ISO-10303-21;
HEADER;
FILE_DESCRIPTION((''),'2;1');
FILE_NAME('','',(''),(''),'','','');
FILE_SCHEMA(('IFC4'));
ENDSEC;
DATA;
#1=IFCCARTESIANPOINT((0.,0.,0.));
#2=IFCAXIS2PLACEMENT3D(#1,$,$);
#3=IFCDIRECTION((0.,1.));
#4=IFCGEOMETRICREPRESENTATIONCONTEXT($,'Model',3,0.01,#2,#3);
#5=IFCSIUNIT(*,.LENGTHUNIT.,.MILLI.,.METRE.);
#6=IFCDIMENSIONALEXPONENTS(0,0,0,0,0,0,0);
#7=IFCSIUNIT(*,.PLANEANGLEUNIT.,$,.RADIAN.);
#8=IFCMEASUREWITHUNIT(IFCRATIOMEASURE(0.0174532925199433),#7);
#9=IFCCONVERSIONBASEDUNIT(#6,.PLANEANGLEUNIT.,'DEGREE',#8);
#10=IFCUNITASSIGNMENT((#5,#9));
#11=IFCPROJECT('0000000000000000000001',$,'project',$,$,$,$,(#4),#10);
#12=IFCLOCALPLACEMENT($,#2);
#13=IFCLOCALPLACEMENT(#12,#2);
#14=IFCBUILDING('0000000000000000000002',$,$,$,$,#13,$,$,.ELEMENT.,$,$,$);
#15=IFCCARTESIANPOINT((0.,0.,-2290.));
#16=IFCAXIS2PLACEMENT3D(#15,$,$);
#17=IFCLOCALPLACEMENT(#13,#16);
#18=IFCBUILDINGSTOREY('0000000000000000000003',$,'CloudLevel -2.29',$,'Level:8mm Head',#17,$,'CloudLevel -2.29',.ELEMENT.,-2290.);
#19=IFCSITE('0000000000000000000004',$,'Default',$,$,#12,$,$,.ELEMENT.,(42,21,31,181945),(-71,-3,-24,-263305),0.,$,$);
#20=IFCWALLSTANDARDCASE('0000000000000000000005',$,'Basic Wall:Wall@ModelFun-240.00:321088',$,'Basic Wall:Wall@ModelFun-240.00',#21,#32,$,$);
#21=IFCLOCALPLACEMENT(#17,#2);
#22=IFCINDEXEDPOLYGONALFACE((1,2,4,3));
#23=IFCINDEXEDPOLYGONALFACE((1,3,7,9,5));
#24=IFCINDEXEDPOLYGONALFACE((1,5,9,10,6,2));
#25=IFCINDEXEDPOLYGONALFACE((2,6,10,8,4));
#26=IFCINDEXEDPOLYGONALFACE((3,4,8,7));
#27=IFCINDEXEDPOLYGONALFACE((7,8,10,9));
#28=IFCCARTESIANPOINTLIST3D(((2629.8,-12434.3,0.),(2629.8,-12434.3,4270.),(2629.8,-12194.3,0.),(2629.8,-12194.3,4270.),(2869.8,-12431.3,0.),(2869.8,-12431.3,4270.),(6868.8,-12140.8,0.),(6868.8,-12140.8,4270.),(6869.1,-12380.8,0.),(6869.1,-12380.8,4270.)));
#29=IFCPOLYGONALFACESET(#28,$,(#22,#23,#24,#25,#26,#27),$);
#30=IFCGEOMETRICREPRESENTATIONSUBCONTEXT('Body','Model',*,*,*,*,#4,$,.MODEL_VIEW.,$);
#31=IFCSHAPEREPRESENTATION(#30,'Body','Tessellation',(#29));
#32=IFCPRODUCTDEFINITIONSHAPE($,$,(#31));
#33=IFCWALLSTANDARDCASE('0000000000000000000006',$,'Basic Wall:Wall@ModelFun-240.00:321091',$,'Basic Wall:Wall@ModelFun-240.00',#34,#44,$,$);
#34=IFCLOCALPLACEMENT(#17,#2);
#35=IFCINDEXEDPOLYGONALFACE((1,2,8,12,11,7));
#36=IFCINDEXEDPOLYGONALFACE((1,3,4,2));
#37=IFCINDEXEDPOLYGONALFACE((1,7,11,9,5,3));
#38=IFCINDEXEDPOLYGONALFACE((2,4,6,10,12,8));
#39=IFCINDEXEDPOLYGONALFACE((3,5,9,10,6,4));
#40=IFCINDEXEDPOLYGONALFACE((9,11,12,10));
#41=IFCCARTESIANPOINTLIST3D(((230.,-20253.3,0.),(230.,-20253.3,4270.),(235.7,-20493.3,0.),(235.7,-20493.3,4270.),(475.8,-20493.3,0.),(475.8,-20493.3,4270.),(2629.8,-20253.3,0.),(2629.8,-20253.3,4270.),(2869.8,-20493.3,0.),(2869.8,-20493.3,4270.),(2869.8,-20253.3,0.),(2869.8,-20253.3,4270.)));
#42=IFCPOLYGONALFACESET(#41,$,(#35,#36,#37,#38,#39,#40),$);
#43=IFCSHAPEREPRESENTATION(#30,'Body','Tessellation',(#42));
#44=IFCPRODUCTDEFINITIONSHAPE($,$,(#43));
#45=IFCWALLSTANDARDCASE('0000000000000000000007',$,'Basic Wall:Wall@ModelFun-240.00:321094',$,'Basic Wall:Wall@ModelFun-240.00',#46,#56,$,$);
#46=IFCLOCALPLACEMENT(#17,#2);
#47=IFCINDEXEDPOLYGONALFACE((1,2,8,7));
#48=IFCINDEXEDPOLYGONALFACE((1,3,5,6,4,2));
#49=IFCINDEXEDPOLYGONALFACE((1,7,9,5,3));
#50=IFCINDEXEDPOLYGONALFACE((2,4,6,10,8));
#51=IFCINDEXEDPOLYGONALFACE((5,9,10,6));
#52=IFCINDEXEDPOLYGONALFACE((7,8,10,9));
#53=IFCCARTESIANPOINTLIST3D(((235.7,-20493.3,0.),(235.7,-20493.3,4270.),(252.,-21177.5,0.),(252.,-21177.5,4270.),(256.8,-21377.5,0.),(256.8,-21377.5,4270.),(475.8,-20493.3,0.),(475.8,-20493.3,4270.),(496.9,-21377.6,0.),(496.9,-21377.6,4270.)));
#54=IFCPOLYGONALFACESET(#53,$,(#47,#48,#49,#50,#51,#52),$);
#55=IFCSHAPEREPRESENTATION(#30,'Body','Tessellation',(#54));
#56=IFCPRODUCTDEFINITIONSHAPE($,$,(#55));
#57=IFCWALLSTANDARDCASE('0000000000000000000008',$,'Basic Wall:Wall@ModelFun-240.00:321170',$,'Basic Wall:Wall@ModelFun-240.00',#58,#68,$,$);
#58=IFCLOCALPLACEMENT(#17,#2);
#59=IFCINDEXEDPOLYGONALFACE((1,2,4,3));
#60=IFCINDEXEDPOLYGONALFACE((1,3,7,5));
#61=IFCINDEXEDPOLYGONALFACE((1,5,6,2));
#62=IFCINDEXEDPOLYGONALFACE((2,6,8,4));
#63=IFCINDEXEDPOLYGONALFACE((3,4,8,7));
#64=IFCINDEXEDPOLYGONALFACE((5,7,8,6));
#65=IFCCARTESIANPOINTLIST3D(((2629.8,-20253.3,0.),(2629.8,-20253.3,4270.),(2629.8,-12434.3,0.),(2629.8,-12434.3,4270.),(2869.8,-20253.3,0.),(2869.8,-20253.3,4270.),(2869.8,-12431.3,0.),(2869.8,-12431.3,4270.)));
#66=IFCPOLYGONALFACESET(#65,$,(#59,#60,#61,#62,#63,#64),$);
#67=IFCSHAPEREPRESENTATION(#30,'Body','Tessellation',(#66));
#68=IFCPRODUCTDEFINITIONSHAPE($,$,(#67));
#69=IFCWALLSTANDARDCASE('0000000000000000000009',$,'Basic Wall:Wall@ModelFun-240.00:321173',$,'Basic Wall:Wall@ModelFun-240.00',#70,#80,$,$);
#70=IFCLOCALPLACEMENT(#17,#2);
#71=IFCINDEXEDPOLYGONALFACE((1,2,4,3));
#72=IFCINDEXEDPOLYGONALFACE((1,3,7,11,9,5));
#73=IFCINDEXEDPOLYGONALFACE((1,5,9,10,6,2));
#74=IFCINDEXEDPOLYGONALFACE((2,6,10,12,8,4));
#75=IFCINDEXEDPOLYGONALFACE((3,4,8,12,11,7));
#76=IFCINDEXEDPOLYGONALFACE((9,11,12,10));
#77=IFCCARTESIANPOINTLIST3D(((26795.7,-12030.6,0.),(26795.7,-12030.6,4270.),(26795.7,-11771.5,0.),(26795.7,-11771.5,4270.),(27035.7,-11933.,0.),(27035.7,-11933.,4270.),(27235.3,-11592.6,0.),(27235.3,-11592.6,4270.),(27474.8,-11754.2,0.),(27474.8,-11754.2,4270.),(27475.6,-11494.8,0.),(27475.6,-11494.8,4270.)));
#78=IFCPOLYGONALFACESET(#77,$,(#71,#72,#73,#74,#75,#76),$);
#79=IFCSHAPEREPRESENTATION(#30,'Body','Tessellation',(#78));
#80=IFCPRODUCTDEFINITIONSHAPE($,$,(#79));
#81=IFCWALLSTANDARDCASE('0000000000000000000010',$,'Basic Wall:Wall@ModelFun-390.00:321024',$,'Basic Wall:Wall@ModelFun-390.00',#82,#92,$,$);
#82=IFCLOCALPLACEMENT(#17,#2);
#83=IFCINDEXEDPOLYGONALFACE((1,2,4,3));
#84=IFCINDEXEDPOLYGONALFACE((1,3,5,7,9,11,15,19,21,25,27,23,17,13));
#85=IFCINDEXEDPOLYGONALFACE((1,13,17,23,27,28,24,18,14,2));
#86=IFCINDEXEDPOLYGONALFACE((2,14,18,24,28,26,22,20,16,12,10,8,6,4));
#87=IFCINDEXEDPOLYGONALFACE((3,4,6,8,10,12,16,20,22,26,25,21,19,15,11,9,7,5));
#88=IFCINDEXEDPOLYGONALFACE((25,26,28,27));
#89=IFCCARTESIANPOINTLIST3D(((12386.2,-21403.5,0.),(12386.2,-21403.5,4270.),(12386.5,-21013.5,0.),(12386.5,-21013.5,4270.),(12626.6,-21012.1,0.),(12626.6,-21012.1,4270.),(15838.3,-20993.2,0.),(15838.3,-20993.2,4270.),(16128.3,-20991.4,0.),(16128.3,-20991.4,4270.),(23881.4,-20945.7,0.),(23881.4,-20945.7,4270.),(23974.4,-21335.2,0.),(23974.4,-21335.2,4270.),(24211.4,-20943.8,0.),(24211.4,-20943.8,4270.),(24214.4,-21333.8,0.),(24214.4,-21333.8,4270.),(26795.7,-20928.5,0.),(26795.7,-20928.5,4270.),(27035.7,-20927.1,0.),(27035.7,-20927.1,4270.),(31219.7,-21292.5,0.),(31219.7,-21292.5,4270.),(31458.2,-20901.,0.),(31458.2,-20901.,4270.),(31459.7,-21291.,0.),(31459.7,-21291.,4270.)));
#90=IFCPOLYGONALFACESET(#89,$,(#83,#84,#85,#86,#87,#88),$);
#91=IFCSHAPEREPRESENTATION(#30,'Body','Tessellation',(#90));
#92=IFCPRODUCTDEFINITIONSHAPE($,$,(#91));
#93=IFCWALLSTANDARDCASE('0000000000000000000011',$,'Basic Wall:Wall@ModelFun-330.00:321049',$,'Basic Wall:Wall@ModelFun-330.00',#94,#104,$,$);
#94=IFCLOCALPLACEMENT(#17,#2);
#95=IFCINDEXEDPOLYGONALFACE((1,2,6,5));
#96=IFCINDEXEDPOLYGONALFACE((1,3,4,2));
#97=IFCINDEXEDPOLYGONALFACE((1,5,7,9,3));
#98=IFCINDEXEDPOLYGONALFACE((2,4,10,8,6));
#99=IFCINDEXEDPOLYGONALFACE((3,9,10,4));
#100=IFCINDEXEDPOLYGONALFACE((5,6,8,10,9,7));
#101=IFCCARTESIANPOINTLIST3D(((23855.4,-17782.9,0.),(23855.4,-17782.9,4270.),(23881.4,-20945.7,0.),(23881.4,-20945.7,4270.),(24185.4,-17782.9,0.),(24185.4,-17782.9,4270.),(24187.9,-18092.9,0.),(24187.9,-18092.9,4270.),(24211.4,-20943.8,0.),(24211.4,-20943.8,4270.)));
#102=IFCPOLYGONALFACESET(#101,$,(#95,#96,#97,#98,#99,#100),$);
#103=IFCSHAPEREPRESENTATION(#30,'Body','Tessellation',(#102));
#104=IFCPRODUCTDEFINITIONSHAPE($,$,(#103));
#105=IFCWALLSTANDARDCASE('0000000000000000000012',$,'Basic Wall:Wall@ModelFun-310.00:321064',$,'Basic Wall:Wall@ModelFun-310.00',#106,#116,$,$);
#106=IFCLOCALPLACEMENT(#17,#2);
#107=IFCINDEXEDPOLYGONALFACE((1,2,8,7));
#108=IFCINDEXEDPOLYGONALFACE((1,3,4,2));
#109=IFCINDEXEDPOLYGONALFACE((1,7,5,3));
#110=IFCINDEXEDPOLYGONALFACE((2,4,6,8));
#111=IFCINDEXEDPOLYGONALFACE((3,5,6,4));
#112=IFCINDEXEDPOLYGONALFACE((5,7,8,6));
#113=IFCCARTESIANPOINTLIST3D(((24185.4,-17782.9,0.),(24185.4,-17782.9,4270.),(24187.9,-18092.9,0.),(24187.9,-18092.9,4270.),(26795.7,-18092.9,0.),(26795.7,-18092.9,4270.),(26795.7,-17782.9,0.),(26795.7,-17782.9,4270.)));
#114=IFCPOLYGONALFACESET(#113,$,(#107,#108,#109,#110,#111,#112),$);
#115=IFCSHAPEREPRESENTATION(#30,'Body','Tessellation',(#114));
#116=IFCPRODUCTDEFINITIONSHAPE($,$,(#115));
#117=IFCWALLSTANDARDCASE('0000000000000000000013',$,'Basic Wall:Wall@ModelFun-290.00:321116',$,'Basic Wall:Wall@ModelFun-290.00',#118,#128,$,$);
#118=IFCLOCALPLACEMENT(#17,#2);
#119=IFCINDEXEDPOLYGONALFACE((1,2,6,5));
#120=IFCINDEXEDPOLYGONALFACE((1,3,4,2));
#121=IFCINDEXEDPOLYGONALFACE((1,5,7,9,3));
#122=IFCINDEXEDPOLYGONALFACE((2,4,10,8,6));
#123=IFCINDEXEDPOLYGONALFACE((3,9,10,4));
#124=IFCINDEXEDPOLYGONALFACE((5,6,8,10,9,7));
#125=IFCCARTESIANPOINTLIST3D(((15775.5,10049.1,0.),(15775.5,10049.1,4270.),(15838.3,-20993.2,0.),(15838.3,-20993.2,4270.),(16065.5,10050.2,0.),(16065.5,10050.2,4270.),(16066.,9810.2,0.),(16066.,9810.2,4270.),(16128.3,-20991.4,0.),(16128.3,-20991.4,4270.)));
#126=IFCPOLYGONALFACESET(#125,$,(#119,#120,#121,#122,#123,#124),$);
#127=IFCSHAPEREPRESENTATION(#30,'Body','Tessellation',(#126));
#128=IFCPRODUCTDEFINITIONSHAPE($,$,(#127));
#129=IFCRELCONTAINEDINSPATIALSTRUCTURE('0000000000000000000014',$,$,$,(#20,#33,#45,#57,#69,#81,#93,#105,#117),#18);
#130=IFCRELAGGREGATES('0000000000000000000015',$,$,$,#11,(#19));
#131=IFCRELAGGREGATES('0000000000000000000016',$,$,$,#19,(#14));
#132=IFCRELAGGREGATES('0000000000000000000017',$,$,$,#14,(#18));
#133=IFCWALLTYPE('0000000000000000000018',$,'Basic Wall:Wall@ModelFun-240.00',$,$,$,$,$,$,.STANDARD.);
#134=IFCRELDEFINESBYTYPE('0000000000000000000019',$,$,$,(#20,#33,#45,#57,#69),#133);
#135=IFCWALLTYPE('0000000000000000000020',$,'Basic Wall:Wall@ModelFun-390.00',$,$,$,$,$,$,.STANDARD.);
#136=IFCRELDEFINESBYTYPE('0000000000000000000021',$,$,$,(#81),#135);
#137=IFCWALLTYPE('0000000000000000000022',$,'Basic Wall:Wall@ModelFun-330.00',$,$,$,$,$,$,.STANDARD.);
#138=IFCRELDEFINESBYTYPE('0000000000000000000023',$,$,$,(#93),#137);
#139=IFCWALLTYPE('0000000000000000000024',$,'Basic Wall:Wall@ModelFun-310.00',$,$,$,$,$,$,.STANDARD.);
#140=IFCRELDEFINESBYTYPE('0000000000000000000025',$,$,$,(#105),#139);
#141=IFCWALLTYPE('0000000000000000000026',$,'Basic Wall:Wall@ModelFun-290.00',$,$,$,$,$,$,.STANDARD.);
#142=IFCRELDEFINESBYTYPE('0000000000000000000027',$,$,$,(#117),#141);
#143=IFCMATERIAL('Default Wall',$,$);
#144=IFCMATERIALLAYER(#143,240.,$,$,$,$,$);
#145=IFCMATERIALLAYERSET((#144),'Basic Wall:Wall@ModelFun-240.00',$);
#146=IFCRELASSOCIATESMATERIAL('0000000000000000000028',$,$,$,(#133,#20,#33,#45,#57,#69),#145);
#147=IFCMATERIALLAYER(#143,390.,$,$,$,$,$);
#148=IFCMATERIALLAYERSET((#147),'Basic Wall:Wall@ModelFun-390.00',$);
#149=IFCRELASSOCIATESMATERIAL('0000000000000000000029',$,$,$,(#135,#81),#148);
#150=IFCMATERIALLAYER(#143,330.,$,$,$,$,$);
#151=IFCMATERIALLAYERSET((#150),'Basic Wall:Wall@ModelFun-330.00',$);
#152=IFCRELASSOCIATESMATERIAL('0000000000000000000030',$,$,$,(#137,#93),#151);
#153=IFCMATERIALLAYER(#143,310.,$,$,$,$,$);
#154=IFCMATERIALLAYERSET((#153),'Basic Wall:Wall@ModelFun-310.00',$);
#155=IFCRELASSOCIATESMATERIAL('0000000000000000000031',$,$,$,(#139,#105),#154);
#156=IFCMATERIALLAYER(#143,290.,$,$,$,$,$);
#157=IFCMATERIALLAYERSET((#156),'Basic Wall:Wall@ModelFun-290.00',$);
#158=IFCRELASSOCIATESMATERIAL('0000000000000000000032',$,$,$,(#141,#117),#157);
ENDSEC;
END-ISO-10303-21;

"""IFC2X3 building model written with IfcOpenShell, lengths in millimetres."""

from ifc_helpers import new_model, entity, si_unit, converted_unit, direction, frame, origin, place, context, subcontext, project, spatial, polyline, outline, extrude, material, layer, layer_set, layer_usage, type_object, element, save


model = new_model("IFC2X3")

# Units and contexts
model_context = context("Model", 3, precision=0.01, world=origin(), true_north=direction((0.0, 1.0)))
body_context = subcontext(model_context, "Body", "Model", "MODEL_VIEW")
ifc_project = project(units=[si_unit("LENGTHUNIT", "METRE", prefix="MILLI"), converted_unit("PLANEANGLEUNIT", "DEGREE", entity("IfcRatioMeasure", 0.0174532925199433), si_unit("PLANEANGLEUNIT", "RADIAN"), dimensions=[0, 0, 0, 0, 0, 0, 0])], contexts=[model_context])

# Site, building, storey
site_placement = place(None, origin())
site = spatial("IfcSite", under=ifc_project, at=site_placement, Name="Default", CompositionType="ELEMENT", RefLatitude=(42, 21, 31, 181945), RefLongitude=(-71, -3, -24, -263305), RefElevation=0.0)
building_placement = place(site_placement, origin())
building = spatial("IfcBuilding", under=site, at=building_placement, CompositionType="ELEMENT")
storey_placement = place(building_placement, frame((0.0, 0.0, -2290.0)))
storey = spatial("IfcBuildingStorey", under=building, at=storey_placement, Name="CloudLevel -2.29", ObjectType="Level:8mm Head", LongName="CloudLevel -2.29", CompositionType="ELEMENT", Elevation=-2290.0)

# Walls
ifc_material_1 = material(Name="Default Wall")
ifc_layer_1 = layer(ifc_material_1, 240.0)
ifc_layer_set_1 = layer_set([ifc_layer_1], Name="Basic Wall:Wall@ModelFun-240.00")
wall_type_1 = type_object("IfcWallType", Name="Basic Wall:Wall@ModelFun-240.00", PredefinedType="STANDARD", material=ifc_layer_set_1)
ifc_layer_usage_1 = layer_usage(ifc_layer_set_1, "AXIS2", "NEGATIVE", 120.0)
wall_1_placement = place(storey_placement, frame((2628.3, -12314.3, 0.0), z_axis=(0.0, 0.0, 1.0), x_axis=(0.99992, 0.012621, 0.0)))
element("IfcWallStandardCase", 1, at=wall_1_placement, inside=storey, type_object=wall_type_1, material=ifc_layer_usage_1, Name="Basic Wall:Wall@ModelFun-240.00:321088", ObjectType="Basic Wall:Wall@ModelFun-240.00", context=body_context, shape_type="SweptSolid", body=[
    extrude(outline(polyline([(4239.6, -120.0), (4242.3, 120.0), (3.0, 120.0), (0.0, -120.0), (240.0, -120.0), (4239.6, -120.0)])), origin(), (0.0, 0.0, 1.0), 4270.0),
])
ifc_layer_usage_2 = layer_usage(ifc_layer_set_1, "AXIS2", "NEGATIVE", 120.0)
wall_2_placement = place(storey_placement, frame((2869.8, -20373.3, 0.0), z_axis=(0.0, 0.0, 1.0), x_axis=(-1.0, 0.0, 0.0)))
element("IfcWallStandardCase", 2, at=wall_2_placement, inside=storey, type_object=wall_type_1, material=ifc_layer_usage_2, Name="Basic Wall:Wall@ModelFun-240.00:321091", ObjectType="Basic Wall:Wall@ModelFun-240.00", context=body_context, shape_type="SweptSolid", body=[
    extrude(outline(polyline([(2639.8, -120.0), (2634.1, 120.0), (2394.0, 120.0), (0.0, 120.0), (0.0, -120.0), (240.0, -120.0), (2639.8, -120.0)])), origin(), (0.0, 0.0, 1.0), 4270.0),
])
ifc_layer_usage_3 = layer_usage(ifc_layer_set_1, "AXIS2", "NEGATIVE", 120.0)
wall_3_placement = place(storey_placement, frame((376.9, -21380.4, 0.0), z_axis=(0.0, 0.0, 1.0), x_axis=(-0.023839, 0.999716, 0.0)))
element("IfcWallStandardCase", 3, at=wall_3_placement, inside=storey, type_object=wall_type_1, material=ifc_layer_usage_3, Name="Basic Wall:Wall@ModelFun-240.00:321094", ObjectType="Basic Wall:Wall@ModelFun-240.00", context=body_context, shape_type="SweptSolid", body=[
    extrude(outline(polyline([(884.5, -120.0), (890.2, 120.0), (205.9, 120.0), (5.8, 120.0), (0.0, -120.0), (884.5, -120.0)])), origin(), (0.0, 0.0, 1.0), 4270.0),
])
ifc_layer_usage_4 = layer_usage(ifc_layer_set_1, "AXIS2", "NEGATIVE", 120.0)
wall_4_placement = place(storey_placement, frame((2749.8, -20253.3, 0.0), z_axis=(0.0, 0.0, 1.0), x_axis=(0.0, 1.0, 0.0)))
element("IfcWallStandardCase", 4, at=wall_4_placement, inside=storey, type_object=wall_type_1, material=ifc_layer_usage_4, Name="Basic Wall:Wall@ModelFun-240.00:321170", ObjectType="Basic Wall:Wall@ModelFun-240.00", context=body_context, shape_type="SweptSolid", body=[
    extrude(outline(polyline([(7822.0, -120.0), (7819.0, 120.0), (0.0, 120.0), (0.0, -120.0), (7822.0, -120.0)])), origin(), (0.0, 0.0, 1.0), 4270.0),
])
ifc_layer_usage_5 = layer_usage(ifc_layer_set_1, "AXIS2", "NEGATIVE", 120.0)
wall_5_placement = place(storey_placement, frame((27520.8, -11606.0, 0.0), z_axis=(0.0, 0.0, 1.0), x_axis=(-0.926248, -0.376915, 0.0)))
element("IfcWallStandardCase", 5, at=wall_5_placement, inside=storey, type_object=wall_type_1, material=ifc_layer_usage_5, Name="Basic Wall:Wall@ModelFun-240.00:321173", ObjectType="Basic Wall:Wall@ModelFun-240.00", context=body_context, shape_type="SweptSolid", body=[
    extrude(outline(polyline([(734.1, -120.0), (831.7, 120.0), (572.6, 120.0), (98.5, 120.0), (0.0, -120.0), (259.4, -120.0), (734.1, -120.0)])), origin(), (0.0, 0.0, 1.0), 4270.0),
])
ifc_layer_2 = layer(ifc_material_1, 390.0)
ifc_layer_set_2 = layer_set([ifc_layer_2], Name="Basic Wall:Wall@ModelFun-390.00")
ifc_layer_usage_6 = layer_usage(ifc_layer_set_2, "AXIS2", "NEGATIVE", 195.0)
wall_type_2 = type_object("IfcWallType", Name="Basic Wall:Wall@ModelFun-390.00", PredefinedType="STANDARD", material=ifc_layer_set_2)
wall_6_placement = place(storey_placement, frame((31459.3, -21096.0, 0.0), z_axis=(0.0, 0.0, 1.0), x_axis=(-0.999983, -0.005897, 0.0)))
element("IfcWallStandardCase", 6, at=wall_6_placement, inside=storey, type_object=wall_type_2, material=ifc_layer_usage_6, Name="Basic Wall:Wall@ModelFun-390.00:321024", ObjectType="Basic Wall:Wall@ModelFun-390.00", context=body_context, shape_type="SweptSolid", body=[
    extrude(outline(polyline([(19072.0, -195.0), (19074.6, 195.0), (7486.2, 195.0), (7246.2, 195.0), (240.8, 195.0), (0.8, 195.0), (0.0, -195.0), (4422.6, -195.0), (4662.6, -195.0), (7246.9, -195.0), (7576.9, -195.0), (15330.1, -195.0), (15620.1, -195.0), (18832.0, -195.0), (19072.0, -195.0)])), origin(), (0.0, 0.0, 1.0), 4270.0),
])
ifc_layer_3 = layer(ifc_material_1, 330.0)
ifc_layer_set_3 = layer_set([ifc_layer_3], Name="Basic Wall:Wall@ModelFun-330.00")
ifc_layer_usage_7 = layer_usage(ifc_layer_set_3, "AXIS2", "NEGATIVE", 165.0)
wall_type_3 = type_object("IfcWallType", Name="Basic Wall:Wall@ModelFun-330.00", PredefinedType="STANDARD", material=ifc_layer_set_3)
wall_7_placement = place(storey_placement, frame((24046.4, -20945.1, 0.0), z_axis=(0.0, 0.0, 1.0), x_axis=(-0.008236, 0.999966, 0.0)))
element("IfcWallStandardCase", 7, at=wall_7_placement, inside=storey, type_object=wall_type_3, material=ifc_layer_usage_7, Name="Basic Wall:Wall@ModelFun-330.00:321049", ObjectType="Basic Wall:Wall@ModelFun-330.00", context=body_context, shape_type="SweptSolid", body=[
    extrude(outline(polyline([(3161.0, -165.0), (3163.7, 165.0), (0.8, 165.0), (0.0, -165.0), (2851.0, -165.0), (3161.0, -165.0)])), origin(), (0.0, 0.0, 1.0), 4270.0),
])
ifc_layer_4 = layer(ifc_material_1, 310.0)
ifc_layer_set_4 = layer_set([ifc_layer_4], Name="Basic Wall:Wall@ModelFun-310.00")
ifc_layer_usage_8 = layer_usage(ifc_layer_set_4, "AXIS2", "NEGATIVE", 155.0)
wall_type_4 = type_object("IfcWallType", Name="Basic Wall:Wall@ModelFun-310.00", PredefinedType="STANDARD", material=ifc_layer_set_4)
wall_8_placement = place(storey_placement, frame((24185.4, -17937.9, 0.0)))
element("IfcWallStandardCase", 8, at=wall_8_placement, inside=storey, type_object=wall_type_4, material=ifc_layer_usage_8, Name="Basic Wall:Wall@ModelFun-310.00:321064", ObjectType="Basic Wall:Wall@ModelFun-310.00", context=body_context, shape_type="SweptSolid", body=[
    extrude(outline(polyline([(2610.3, -155.0), (2610.3, 155.0), (0.0, 155.0), (2.6, -155.0), (2610.3, -155.0)])), origin(), (0.0, 0.0, 1.0), 4270.0),
])
ifc_layer_5 = layer(ifc_material_1, 290.0)
ifc_layer_set_5 = layer_set([ifc_layer_5], Name="Basic Wall:Wall@ModelFun-290.00")
ifc_layer_usage_9 = layer_usage(ifc_layer_set_5, "AXIS2", "NEGATIVE", 145.0)
wall_type_5 = type_object("IfcWallType", Name="Basic Wall:Wall@ModelFun-290.00", PredefinedType="STANDARD", material=ifc_layer_set_5)
wall_9_placement = place(storey_placement, frame((15983.3, -20992.9, 0.0), z_axis=(0.0, 0.0, 1.0), x_axis=(-0.002024, 0.999998, 0.0)))
element("IfcWallStandardCase", 9, at=wall_9_placement, inside=storey, type_object=wall_type_5, material=ifc_layer_usage_9, Name="Basic Wall:Wall@ModelFun-290.00:321116", ObjectType="Basic Wall:Wall@ModelFun-290.00", context=body_context, shape_type="SweptSolid", body=[
    extrude(outline(polyline([(31042.8, -145.0), (31042.3, 145.0), (0.0, 145.0), (1.1, -145.0), (30802.8, -145.0), (31042.8, -145.0)])), origin(), (0.0, 0.0, 1.0), 4270.0),
])

save(model, "model.ifc")
